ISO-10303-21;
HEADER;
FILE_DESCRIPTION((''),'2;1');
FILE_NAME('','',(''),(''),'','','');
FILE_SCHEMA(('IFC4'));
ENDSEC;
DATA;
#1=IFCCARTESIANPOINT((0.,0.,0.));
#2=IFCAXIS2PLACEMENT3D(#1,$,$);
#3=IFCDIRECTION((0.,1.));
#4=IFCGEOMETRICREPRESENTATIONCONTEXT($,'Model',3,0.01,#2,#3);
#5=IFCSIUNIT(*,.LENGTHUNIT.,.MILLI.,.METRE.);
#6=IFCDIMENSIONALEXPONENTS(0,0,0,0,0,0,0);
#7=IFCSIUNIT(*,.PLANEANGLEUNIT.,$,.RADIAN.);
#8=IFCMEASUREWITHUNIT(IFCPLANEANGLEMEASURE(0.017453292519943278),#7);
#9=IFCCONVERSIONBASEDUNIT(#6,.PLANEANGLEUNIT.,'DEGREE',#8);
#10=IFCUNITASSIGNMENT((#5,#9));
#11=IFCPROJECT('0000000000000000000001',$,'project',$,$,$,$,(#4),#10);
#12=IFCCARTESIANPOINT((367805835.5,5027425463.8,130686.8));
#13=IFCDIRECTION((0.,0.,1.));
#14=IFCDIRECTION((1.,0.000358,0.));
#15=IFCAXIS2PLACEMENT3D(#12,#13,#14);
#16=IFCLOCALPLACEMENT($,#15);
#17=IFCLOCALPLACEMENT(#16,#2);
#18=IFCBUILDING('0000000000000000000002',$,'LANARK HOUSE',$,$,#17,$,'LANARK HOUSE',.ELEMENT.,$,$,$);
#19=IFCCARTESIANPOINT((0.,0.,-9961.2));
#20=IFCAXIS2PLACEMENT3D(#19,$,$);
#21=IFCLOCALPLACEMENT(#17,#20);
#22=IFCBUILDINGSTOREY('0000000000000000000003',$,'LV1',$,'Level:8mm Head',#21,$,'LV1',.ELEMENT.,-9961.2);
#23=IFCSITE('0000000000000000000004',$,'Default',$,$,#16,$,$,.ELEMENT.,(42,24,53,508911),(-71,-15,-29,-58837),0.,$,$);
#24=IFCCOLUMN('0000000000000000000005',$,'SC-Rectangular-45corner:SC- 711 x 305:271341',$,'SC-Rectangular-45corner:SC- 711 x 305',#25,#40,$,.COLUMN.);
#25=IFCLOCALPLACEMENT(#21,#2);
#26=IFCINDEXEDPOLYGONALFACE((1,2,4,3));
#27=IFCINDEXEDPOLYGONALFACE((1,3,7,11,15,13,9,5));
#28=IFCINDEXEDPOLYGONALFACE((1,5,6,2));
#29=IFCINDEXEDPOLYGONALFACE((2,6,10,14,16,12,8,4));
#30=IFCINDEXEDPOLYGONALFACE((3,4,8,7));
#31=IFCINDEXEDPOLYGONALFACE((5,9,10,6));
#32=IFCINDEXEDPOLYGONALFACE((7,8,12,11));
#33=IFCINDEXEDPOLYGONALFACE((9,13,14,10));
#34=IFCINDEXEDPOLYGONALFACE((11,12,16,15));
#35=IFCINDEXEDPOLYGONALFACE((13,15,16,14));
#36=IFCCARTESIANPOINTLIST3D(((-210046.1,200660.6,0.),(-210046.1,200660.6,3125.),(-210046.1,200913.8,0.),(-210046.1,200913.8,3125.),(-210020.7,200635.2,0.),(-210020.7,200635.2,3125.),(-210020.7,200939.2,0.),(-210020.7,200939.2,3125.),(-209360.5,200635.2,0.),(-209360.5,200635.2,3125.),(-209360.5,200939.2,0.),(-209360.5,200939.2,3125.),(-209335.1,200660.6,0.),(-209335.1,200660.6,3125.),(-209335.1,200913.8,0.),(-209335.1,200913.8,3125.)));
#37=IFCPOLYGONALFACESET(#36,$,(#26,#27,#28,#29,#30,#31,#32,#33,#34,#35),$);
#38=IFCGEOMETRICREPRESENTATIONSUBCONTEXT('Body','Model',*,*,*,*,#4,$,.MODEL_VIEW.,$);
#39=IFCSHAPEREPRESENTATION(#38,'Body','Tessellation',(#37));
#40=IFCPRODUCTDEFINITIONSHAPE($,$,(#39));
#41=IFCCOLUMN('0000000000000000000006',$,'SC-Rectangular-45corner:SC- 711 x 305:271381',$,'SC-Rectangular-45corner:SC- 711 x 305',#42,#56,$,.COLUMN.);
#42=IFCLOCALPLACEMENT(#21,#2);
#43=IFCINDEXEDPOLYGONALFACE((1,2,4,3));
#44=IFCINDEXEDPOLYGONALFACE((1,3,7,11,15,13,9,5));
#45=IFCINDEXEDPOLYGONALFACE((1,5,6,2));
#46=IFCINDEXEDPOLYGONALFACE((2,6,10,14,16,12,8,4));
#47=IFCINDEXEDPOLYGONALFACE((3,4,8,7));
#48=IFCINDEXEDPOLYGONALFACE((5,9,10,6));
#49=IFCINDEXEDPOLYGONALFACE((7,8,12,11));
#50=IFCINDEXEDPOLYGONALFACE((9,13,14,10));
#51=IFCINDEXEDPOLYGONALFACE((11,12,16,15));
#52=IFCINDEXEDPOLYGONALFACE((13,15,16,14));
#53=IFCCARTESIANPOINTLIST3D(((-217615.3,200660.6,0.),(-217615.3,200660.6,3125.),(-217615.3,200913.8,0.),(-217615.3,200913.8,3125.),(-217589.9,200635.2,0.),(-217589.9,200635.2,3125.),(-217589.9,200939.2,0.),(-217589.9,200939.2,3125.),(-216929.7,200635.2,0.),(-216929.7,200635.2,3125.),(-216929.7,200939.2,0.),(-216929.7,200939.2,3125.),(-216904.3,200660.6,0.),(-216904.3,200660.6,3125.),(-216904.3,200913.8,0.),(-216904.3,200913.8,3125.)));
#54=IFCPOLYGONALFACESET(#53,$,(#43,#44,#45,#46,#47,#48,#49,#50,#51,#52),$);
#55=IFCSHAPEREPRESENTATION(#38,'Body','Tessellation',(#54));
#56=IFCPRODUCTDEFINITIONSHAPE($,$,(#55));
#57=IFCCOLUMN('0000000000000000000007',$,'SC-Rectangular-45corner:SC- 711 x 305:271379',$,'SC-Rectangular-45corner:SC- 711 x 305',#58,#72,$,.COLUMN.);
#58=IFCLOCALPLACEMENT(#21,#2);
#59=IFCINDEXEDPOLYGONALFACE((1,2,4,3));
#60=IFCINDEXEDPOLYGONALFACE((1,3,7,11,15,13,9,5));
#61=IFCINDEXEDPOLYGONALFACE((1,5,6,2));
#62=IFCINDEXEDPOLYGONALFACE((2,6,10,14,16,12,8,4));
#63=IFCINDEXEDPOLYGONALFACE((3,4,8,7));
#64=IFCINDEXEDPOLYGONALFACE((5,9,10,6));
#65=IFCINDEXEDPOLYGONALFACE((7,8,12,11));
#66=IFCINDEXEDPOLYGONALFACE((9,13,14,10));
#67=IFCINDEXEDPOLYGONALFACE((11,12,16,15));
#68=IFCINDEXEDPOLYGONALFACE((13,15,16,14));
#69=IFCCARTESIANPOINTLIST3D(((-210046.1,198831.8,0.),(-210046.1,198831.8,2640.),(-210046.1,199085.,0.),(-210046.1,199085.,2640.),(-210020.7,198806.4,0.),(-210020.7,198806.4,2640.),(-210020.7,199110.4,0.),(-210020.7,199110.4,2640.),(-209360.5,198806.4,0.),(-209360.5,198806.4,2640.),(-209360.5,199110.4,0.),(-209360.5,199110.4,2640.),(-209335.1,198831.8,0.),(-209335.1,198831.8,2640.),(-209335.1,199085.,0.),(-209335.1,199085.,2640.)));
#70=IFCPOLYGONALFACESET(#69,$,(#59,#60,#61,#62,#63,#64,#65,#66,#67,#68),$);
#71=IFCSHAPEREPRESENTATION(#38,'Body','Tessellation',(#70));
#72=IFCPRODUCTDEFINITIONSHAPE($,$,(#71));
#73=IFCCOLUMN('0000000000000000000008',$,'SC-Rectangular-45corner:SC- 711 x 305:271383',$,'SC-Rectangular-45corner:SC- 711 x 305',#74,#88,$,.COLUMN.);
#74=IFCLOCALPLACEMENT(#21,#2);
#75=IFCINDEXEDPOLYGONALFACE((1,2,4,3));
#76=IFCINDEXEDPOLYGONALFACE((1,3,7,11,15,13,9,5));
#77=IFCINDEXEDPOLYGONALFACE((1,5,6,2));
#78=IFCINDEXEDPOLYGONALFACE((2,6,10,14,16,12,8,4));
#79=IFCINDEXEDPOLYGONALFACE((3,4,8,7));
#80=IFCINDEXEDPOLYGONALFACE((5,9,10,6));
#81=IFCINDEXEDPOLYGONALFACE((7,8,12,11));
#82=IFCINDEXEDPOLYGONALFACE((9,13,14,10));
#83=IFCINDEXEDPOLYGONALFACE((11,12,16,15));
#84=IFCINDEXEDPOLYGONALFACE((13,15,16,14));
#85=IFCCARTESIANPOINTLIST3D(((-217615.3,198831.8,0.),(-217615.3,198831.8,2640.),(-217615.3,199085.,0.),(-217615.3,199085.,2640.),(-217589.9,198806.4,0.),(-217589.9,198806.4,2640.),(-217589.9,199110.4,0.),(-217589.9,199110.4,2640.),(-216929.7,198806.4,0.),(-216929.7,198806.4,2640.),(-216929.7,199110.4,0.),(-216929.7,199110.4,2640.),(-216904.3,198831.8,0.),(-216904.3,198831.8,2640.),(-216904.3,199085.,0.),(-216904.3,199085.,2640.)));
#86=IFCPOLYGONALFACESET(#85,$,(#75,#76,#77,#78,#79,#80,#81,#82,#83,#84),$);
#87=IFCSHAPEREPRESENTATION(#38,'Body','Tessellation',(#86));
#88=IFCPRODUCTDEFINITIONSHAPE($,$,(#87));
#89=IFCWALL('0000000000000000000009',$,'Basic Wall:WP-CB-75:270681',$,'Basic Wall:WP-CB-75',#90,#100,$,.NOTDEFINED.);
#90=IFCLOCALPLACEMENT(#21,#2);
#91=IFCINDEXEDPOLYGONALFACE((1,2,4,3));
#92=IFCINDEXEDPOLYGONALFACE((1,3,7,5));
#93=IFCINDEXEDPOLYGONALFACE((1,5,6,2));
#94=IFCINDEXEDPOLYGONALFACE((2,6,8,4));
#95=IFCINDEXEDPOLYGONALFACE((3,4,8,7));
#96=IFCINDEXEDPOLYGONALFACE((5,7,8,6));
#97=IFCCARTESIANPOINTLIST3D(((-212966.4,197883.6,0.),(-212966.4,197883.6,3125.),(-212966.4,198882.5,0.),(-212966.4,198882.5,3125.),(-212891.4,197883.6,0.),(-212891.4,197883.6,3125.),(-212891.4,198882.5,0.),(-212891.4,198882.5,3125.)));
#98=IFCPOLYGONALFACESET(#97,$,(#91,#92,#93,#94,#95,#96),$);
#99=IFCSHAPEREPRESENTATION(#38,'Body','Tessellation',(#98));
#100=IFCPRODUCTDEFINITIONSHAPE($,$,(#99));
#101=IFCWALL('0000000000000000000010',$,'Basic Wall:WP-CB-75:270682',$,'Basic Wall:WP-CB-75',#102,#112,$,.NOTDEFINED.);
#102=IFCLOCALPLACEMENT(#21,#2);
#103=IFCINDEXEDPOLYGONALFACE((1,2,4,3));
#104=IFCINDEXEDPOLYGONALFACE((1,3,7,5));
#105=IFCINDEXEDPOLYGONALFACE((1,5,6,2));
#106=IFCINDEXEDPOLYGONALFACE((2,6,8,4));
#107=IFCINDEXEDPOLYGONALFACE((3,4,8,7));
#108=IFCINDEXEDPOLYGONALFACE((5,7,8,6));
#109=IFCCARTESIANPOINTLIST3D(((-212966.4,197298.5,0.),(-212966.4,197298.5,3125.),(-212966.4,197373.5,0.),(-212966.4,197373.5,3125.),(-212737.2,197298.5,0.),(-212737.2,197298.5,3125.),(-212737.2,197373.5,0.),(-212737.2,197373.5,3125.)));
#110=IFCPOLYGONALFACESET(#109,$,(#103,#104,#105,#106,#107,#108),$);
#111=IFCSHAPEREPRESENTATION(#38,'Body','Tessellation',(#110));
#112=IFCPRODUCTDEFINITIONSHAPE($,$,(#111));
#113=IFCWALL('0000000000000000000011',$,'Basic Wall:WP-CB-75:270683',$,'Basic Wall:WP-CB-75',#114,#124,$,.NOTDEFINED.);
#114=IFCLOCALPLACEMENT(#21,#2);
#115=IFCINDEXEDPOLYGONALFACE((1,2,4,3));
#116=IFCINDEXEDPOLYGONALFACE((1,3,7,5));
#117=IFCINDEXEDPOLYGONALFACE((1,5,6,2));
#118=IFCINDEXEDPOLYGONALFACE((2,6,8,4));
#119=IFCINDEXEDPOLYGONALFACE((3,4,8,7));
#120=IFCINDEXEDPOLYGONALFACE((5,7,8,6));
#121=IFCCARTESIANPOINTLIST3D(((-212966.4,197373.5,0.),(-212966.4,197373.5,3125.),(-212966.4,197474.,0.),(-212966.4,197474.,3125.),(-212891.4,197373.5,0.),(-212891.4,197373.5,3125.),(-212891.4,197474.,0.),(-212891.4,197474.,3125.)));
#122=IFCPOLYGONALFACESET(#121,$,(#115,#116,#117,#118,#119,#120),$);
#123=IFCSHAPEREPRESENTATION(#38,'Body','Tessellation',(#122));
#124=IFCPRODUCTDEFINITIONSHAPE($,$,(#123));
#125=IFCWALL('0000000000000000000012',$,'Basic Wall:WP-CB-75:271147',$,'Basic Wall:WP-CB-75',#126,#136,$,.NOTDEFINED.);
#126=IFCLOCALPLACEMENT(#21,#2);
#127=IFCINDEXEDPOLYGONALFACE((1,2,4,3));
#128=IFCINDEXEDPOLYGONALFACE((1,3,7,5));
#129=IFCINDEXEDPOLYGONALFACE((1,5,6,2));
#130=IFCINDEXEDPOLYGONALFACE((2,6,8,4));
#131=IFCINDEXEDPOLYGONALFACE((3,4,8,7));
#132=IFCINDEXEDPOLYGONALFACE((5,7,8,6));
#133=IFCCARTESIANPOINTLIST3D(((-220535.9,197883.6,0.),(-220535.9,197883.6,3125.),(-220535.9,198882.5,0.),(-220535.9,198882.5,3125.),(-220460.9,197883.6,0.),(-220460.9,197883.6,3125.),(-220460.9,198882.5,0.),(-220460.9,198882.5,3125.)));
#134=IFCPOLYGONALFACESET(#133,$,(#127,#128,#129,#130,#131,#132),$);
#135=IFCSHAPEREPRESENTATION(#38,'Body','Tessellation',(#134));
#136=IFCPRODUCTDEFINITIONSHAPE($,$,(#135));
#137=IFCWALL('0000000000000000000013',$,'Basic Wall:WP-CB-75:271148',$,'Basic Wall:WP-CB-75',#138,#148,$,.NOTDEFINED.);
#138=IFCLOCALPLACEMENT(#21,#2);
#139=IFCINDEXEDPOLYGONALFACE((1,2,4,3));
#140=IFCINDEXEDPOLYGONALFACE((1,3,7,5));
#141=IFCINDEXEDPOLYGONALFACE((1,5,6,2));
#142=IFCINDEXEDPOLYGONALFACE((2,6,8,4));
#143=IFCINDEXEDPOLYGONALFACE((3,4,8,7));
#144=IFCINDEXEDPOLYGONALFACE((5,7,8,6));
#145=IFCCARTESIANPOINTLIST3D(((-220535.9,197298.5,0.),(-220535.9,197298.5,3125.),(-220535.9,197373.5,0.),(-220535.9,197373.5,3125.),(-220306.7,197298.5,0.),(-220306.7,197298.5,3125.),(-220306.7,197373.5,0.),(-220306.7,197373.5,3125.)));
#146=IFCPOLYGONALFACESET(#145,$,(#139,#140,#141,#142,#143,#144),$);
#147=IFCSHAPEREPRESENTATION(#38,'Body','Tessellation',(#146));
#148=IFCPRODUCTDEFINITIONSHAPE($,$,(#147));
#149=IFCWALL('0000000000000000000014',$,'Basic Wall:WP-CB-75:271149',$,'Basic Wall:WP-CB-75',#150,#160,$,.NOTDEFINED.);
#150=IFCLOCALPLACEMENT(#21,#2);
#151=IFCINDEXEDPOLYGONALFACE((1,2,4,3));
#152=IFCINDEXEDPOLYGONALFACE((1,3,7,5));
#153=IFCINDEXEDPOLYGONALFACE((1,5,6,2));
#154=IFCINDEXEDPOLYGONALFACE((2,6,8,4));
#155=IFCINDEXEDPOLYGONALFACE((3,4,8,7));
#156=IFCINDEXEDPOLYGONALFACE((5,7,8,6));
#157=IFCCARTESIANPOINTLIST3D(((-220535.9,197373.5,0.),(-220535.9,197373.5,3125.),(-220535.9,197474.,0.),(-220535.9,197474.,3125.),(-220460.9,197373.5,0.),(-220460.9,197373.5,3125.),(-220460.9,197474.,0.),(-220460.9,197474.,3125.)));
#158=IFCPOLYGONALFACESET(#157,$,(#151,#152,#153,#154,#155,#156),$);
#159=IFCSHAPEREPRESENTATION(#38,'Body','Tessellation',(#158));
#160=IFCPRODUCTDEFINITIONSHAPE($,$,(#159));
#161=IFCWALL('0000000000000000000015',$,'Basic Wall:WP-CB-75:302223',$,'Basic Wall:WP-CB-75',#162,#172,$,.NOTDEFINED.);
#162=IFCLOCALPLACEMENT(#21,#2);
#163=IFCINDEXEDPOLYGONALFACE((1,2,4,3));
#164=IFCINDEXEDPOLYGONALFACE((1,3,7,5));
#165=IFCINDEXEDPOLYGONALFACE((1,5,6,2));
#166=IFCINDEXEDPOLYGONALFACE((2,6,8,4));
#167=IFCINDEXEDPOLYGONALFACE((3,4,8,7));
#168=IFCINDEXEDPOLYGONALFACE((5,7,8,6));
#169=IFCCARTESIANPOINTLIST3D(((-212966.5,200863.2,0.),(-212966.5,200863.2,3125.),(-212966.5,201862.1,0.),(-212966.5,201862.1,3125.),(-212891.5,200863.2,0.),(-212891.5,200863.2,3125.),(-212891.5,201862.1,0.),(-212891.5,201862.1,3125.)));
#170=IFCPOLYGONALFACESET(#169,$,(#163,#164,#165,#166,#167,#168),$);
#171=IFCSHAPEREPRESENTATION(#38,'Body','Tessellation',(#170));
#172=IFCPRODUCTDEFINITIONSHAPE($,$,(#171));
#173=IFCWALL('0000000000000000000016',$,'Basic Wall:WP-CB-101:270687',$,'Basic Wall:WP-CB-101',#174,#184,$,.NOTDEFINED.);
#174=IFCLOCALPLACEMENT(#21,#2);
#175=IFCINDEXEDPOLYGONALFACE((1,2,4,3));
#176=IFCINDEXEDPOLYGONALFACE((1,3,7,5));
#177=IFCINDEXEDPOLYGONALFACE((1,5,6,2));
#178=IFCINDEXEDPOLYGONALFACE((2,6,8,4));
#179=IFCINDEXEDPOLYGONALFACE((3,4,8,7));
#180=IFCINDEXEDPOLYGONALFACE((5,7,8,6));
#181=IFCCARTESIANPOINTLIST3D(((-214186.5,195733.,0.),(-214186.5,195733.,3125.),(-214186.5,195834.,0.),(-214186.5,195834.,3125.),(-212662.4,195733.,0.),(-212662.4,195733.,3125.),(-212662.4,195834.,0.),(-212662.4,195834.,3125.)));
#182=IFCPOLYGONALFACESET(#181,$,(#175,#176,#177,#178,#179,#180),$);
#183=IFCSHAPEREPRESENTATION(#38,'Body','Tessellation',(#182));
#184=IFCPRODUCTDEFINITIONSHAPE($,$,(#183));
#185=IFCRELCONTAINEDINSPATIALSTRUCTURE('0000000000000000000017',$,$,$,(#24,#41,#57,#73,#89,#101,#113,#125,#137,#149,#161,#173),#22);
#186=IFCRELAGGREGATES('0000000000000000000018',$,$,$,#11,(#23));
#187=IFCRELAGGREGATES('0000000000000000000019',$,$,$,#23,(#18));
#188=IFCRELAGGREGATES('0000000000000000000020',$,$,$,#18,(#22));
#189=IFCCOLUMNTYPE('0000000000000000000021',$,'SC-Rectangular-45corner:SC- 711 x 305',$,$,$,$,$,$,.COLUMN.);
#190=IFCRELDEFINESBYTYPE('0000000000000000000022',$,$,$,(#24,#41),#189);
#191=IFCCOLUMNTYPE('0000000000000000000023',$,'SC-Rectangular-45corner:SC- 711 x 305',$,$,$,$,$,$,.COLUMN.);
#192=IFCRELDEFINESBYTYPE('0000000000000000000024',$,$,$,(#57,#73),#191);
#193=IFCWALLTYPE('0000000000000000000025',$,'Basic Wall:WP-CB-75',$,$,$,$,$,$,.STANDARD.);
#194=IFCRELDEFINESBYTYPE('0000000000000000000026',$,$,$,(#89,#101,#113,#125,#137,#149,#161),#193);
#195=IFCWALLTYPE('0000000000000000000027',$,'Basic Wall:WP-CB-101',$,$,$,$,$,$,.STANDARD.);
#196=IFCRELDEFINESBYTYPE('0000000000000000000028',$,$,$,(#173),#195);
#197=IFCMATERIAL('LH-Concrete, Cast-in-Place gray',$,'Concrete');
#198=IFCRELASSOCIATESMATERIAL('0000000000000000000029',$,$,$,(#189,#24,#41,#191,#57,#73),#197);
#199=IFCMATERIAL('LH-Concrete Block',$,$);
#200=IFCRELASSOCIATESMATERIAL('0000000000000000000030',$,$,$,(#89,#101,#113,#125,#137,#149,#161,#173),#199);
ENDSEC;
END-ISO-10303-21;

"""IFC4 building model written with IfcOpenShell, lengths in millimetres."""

from ifc_helpers import new_model, entity, si_unit, converted_unit, direction, frame, origin, place, context, subcontext, project, spatial, indexed_curve, outline, extrude, source, transform, mapped, material, type_object, type_shapes, element, save


model = new_model("IFC4")

# Units and contexts
model_context = context("Model", 3, precision=0.01, world=origin(), true_north=direction((0.0, 1.0)))
body_context = subcontext(model_context, "Body", "Model", "MODEL_VIEW")
ifc_project = project(units=[si_unit("LENGTHUNIT", "METRE", prefix="MILLI"), converted_unit("PLANEANGLEUNIT", "DEGREE", entity("IfcPlaneAngleMeasure", 0.017453292519943278), si_unit("PLANEANGLEUNIT", "RADIAN"), dimensions=[0, 0, 0, 0, 0, 0, 0])], contexts=[model_context])

# Site, building, storey
site_placement = place(None, frame((367805835.5, 5027425463.8, 130686.8), z_axis=(0.0, 0.0, 1.0), x_axis=(1.0, 0.000358, 0.0)))
site = spatial("IfcSite", under=ifc_project, at=site_placement, Name="Default", CompositionType="ELEMENT", RefLatitude=(42, 24, 53, 508911), RefLongitude=(-71, -15, -29, -58837), RefElevation=0.0)
building_placement = place(site_placement, origin())
building = spatial("IfcBuilding", under=site, at=building_placement, Name="LANARK HOUSE", LongName="LANARK HOUSE", CompositionType="ELEMENT")
storey_placement = place(building_placement, frame((0.0, 0.0, -9961.2)))
storey = spatial("IfcBuildingStorey", under=building, at=storey_placement, Name="LV1", ObjectType="Level:8mm Head", LongName="LV1", CompositionType="ELEMENT", Elevation=-9961.2)

# Columns
ifc_material_1 = material(Name="LH-Concrete, Cast-in-Place gray", Category="Concrete")
column_type_1 = type_object("IfcColumnType", Name="SC-Rectangular-45corner:SC- 711 x 305", PredefinedType="COLUMN", material=ifc_material_1)
shared_shape_1 = source(origin(), body_context, "Body", "SweptSolid", [
    extrude(outline(indexed_curve([(-330.1, -152.0), (330.1, -152.0), (355.5, -126.6), (355.5, 126.6), (330.1, 152.0), (-330.1, 152.0), (-355.5, 126.6), (-355.5, -126.6), (-330.1, -152.0)], self_intersect=False)), frame((0.0, 0.0, -9961.2), z_axis=(0.0, 0.0, 1.0), x_axis=(-1.0, 0.0, 0.0)), (0.0, 0.0, 1.0), 3125.0),
])
type_shapes(column_type_1, [shared_shape_1])
for number, where, name in (
    (1, (-209690.6, 200787.2, 9961.2), "SC-Rectangular-45corner:SC- 711 x 305:271341"),
    (2, (-217259.8, 200787.2, 9961.2), "SC-Rectangular-45corner:SC- 711 x 305:271381"),
):
    element("IfcColumn", number, at=place(storey_placement, frame(where)), inside=storey, type_object=column_type_1, material=ifc_material_1, Name=name, ObjectType="SC-Rectangular-45corner:SC- 711 x 305", PredefinedType="COLUMN", context=body_context, shape_type="MappedRepresentation", body=[
        mapped(shared_shape_1, transform((0.0, 0.0, 0.0), scale=1.0)),
    ])
column_type_2 = type_object("IfcColumnType", Name="SC-Rectangular-45corner:SC- 711 x 305", PredefinedType="COLUMN", material=ifc_material_1)
shared_shape_2 = source(origin(), body_context, "Body", "SweptSolid", [
    extrude(outline(indexed_curve([(-330.1, -152.0), (330.1, -152.0), (355.5, -126.6), (355.5, 126.6), (330.1, 152.0), (-330.1, 152.0), (-355.5, 126.6), (-355.5, -126.6), (-330.1, -152.0)], self_intersect=False)), frame((0.0, 0.0, -9961.2), z_axis=(0.0, 0.0, 1.0), x_axis=(-1.0, 0.0, 0.0)), (0.0, 0.0, 1.0), 2640.0),
])
type_shapes(column_type_2, [shared_shape_2])
for number, where, name in (
    (3, (-209690.6, 198958.4, 9961.2), "SC-Rectangular-45corner:SC- 711 x 305:271379"),
    (4, (-217259.8, 198958.4, 9961.2), "SC-Rectangular-45corner:SC- 711 x 305:271383"),
):
    element("IfcColumn", number, at=place(storey_placement, frame(where)), inside=storey, type_object=column_type_2, material=ifc_material_1, Name=name, ObjectType="SC-Rectangular-45corner:SC- 711 x 305", PredefinedType="COLUMN", context=body_context, shape_type="MappedRepresentation", body=[
        mapped(shared_shape_2, transform((0.0, 0.0, 0.0), scale=1.0)),
    ])

# Walls
ifc_material_2 = material(Name="LH-Concrete Block")
wall_type_1 = type_object("IfcWallType", Name="Basic Wall:WP-CB-75", PredefinedType="STANDARD")
wall_1_placement = place(storey_placement, frame((-212928.9, 198882.5, 0.0), z_axis=(0.0, 0.0, 1.0), x_axis=(0.0, -1.0, 0.0)))
element("IfcWall", 5, at=wall_1_placement, inside=storey, type_object=wall_type_1, material=ifc_material_2, Name="Basic Wall:WP-CB-75:270681", ObjectType="Basic Wall:WP-CB-75", PredefinedType="NOTDEFINED", context=body_context, shape_type="SweptSolid", body=[
    extrude(outline(indexed_curve([(998.9, 37.5), (0.0, 37.5), (0.0, -37.5), (998.9, -37.5), (998.9, 37.5)], self_intersect=False)), origin(), (0.0, 0.0, 1.0), 3125.0),
])
wall_2_placement = place(storey_placement, frame((-212737.2, 197336.0, 0.0), z_axis=(0.0, 0.0, 1.0), x_axis=(-1.0, 0.0, 0.0)))
element("IfcWall", 6, at=wall_2_placement, inside=storey, type_object=wall_type_1, material=ifc_material_2, Name="Basic Wall:WP-CB-75:270682", ObjectType="Basic Wall:WP-CB-75", PredefinedType="NOTDEFINED", context=body_context, shape_type="SweptSolid", body=[
    extrude(outline(indexed_curve([(229.2, 37.5), (0.0, 37.5), (0.0, -37.5), (229.2, -37.5), (229.2, 37.5)], self_intersect=False)), origin(), (0.0, 0.0, 1.0), 3125.0),
])
wall_3_placement = place(storey_placement, frame((-212928.9, 197373.5, 0.0), z_axis=(0.0, 0.0, 1.0), x_axis=(0.0, 1.0, 0.0)))
element("IfcWall", 7, at=wall_3_placement, inside=storey, type_object=wall_type_1, material=ifc_material_2, Name="Basic Wall:WP-CB-75:270683", ObjectType="Basic Wall:WP-CB-75", PredefinedType="NOTDEFINED", context=body_context, shape_type="SweptSolid", body=[
    extrude(outline(indexed_curve([(100.5, 37.5), (0.0, 37.5), (0.0, -37.5), (100.5, -37.5), (100.5, 37.5)], self_intersect=False)), origin(), (0.0, 0.0, 1.0), 3125.0),
])
wall_4_placement = place(storey_placement, frame((-220498.4, 198882.5, 0.0), z_axis=(0.0, 0.0, 1.0), x_axis=(0.0, -1.0, 0.0)))
element("IfcWall", 8, at=wall_4_placement, inside=storey, type_object=wall_type_1, material=ifc_material_2, Name="Basic Wall:WP-CB-75:271147", ObjectType="Basic Wall:WP-CB-75", PredefinedType="NOTDEFINED", context=body_context, shape_type="SweptSolid", body=[
    extrude(outline(indexed_curve([(998.9, 37.5), (0.0, 37.5), (0.0, -37.5), (998.9, -37.5), (998.9, 37.5)], self_intersect=False)), origin(), (0.0, 0.0, 1.0), 3125.0),
])
wall_5_placement = place(storey_placement, frame((-220306.7, 197336.0, 0.0), z_axis=(0.0, 0.0, 1.0), x_axis=(-1.0, 0.0, 0.0)))
element("IfcWall", 9, at=wall_5_placement, inside=storey, type_object=wall_type_1, material=ifc_material_2, Name="Basic Wall:WP-CB-75:271148", ObjectType="Basic Wall:WP-CB-75", PredefinedType="NOTDEFINED", context=body_context, shape_type="SweptSolid", body=[
    extrude(outline(indexed_curve([(229.2, 37.5), (0.0, 37.5), (0.0, -37.5), (229.2, -37.5), (229.2, 37.5)], self_intersect=False)), origin(), (0.0, 0.0, 1.0), 3125.0),
])
wall_6_placement = place(storey_placement, frame((-220498.4, 197373.5, 0.0), z_axis=(0.0, 0.0, 1.0), x_axis=(0.0, 1.0, 0.0)))
element("IfcWall", 10, at=wall_6_placement, inside=storey, type_object=wall_type_1, material=ifc_material_2, Name="Basic Wall:WP-CB-75:271149", ObjectType="Basic Wall:WP-CB-75", PredefinedType="NOTDEFINED", context=body_context, shape_type="SweptSolid", body=[
    extrude(outline(indexed_curve([(100.5, 37.5), (0.0, 37.5), (0.0, -37.5), (100.5, -37.5), (100.5, 37.5)], self_intersect=False)), origin(), (0.0, 0.0, 1.0), 3125.0),
])
wall_7_placement = place(storey_placement, frame((-212929.0, 200863.2, 0.0), z_axis=(0.0, 0.0, 1.0), x_axis=(0.0, 1.0, 0.0)))
element("IfcWall", 11, at=wall_7_placement, inside=storey, type_object=wall_type_1, material=ifc_material_2, Name="Basic Wall:WP-CB-75:302223", ObjectType="Basic Wall:WP-CB-75", PredefinedType="NOTDEFINED", context=body_context, shape_type="SweptSolid", body=[
    extrude(outline(indexed_curve([(998.8, 37.5), (0.0, 37.5), (0.0, -37.5), (998.8, -37.5), (998.8, 37.5)], self_intersect=False)), origin(), (0.0, 0.0, 1.0), 3125.0),
])
wall_type_2 = type_object("IfcWallType", Name="Basic Wall:WP-CB-101", PredefinedType="STANDARD")
wall_8_placement = place(storey_placement, frame((-214186.5, 195783.5, 0.0)))
element("IfcWall", 12, at=wall_8_placement, inside=storey, type_object=wall_type_2, material=ifc_material_2, Name="Basic Wall:WP-CB-101:270687", ObjectType="Basic Wall:WP-CB-101", PredefinedType="NOTDEFINED", context=body_context, shape_type="SweptSolid", body=[
    extrude(outline(indexed_curve([(1524.1, 50.5), (0.0, 50.5), (0.0, -50.5), (1524.1, -50.5), (1524.1, 50.5)], self_intersect=False)), origin(), (0.0, 0.0, 1.0), 3125.0),
])

save(model, "model.ifc")
